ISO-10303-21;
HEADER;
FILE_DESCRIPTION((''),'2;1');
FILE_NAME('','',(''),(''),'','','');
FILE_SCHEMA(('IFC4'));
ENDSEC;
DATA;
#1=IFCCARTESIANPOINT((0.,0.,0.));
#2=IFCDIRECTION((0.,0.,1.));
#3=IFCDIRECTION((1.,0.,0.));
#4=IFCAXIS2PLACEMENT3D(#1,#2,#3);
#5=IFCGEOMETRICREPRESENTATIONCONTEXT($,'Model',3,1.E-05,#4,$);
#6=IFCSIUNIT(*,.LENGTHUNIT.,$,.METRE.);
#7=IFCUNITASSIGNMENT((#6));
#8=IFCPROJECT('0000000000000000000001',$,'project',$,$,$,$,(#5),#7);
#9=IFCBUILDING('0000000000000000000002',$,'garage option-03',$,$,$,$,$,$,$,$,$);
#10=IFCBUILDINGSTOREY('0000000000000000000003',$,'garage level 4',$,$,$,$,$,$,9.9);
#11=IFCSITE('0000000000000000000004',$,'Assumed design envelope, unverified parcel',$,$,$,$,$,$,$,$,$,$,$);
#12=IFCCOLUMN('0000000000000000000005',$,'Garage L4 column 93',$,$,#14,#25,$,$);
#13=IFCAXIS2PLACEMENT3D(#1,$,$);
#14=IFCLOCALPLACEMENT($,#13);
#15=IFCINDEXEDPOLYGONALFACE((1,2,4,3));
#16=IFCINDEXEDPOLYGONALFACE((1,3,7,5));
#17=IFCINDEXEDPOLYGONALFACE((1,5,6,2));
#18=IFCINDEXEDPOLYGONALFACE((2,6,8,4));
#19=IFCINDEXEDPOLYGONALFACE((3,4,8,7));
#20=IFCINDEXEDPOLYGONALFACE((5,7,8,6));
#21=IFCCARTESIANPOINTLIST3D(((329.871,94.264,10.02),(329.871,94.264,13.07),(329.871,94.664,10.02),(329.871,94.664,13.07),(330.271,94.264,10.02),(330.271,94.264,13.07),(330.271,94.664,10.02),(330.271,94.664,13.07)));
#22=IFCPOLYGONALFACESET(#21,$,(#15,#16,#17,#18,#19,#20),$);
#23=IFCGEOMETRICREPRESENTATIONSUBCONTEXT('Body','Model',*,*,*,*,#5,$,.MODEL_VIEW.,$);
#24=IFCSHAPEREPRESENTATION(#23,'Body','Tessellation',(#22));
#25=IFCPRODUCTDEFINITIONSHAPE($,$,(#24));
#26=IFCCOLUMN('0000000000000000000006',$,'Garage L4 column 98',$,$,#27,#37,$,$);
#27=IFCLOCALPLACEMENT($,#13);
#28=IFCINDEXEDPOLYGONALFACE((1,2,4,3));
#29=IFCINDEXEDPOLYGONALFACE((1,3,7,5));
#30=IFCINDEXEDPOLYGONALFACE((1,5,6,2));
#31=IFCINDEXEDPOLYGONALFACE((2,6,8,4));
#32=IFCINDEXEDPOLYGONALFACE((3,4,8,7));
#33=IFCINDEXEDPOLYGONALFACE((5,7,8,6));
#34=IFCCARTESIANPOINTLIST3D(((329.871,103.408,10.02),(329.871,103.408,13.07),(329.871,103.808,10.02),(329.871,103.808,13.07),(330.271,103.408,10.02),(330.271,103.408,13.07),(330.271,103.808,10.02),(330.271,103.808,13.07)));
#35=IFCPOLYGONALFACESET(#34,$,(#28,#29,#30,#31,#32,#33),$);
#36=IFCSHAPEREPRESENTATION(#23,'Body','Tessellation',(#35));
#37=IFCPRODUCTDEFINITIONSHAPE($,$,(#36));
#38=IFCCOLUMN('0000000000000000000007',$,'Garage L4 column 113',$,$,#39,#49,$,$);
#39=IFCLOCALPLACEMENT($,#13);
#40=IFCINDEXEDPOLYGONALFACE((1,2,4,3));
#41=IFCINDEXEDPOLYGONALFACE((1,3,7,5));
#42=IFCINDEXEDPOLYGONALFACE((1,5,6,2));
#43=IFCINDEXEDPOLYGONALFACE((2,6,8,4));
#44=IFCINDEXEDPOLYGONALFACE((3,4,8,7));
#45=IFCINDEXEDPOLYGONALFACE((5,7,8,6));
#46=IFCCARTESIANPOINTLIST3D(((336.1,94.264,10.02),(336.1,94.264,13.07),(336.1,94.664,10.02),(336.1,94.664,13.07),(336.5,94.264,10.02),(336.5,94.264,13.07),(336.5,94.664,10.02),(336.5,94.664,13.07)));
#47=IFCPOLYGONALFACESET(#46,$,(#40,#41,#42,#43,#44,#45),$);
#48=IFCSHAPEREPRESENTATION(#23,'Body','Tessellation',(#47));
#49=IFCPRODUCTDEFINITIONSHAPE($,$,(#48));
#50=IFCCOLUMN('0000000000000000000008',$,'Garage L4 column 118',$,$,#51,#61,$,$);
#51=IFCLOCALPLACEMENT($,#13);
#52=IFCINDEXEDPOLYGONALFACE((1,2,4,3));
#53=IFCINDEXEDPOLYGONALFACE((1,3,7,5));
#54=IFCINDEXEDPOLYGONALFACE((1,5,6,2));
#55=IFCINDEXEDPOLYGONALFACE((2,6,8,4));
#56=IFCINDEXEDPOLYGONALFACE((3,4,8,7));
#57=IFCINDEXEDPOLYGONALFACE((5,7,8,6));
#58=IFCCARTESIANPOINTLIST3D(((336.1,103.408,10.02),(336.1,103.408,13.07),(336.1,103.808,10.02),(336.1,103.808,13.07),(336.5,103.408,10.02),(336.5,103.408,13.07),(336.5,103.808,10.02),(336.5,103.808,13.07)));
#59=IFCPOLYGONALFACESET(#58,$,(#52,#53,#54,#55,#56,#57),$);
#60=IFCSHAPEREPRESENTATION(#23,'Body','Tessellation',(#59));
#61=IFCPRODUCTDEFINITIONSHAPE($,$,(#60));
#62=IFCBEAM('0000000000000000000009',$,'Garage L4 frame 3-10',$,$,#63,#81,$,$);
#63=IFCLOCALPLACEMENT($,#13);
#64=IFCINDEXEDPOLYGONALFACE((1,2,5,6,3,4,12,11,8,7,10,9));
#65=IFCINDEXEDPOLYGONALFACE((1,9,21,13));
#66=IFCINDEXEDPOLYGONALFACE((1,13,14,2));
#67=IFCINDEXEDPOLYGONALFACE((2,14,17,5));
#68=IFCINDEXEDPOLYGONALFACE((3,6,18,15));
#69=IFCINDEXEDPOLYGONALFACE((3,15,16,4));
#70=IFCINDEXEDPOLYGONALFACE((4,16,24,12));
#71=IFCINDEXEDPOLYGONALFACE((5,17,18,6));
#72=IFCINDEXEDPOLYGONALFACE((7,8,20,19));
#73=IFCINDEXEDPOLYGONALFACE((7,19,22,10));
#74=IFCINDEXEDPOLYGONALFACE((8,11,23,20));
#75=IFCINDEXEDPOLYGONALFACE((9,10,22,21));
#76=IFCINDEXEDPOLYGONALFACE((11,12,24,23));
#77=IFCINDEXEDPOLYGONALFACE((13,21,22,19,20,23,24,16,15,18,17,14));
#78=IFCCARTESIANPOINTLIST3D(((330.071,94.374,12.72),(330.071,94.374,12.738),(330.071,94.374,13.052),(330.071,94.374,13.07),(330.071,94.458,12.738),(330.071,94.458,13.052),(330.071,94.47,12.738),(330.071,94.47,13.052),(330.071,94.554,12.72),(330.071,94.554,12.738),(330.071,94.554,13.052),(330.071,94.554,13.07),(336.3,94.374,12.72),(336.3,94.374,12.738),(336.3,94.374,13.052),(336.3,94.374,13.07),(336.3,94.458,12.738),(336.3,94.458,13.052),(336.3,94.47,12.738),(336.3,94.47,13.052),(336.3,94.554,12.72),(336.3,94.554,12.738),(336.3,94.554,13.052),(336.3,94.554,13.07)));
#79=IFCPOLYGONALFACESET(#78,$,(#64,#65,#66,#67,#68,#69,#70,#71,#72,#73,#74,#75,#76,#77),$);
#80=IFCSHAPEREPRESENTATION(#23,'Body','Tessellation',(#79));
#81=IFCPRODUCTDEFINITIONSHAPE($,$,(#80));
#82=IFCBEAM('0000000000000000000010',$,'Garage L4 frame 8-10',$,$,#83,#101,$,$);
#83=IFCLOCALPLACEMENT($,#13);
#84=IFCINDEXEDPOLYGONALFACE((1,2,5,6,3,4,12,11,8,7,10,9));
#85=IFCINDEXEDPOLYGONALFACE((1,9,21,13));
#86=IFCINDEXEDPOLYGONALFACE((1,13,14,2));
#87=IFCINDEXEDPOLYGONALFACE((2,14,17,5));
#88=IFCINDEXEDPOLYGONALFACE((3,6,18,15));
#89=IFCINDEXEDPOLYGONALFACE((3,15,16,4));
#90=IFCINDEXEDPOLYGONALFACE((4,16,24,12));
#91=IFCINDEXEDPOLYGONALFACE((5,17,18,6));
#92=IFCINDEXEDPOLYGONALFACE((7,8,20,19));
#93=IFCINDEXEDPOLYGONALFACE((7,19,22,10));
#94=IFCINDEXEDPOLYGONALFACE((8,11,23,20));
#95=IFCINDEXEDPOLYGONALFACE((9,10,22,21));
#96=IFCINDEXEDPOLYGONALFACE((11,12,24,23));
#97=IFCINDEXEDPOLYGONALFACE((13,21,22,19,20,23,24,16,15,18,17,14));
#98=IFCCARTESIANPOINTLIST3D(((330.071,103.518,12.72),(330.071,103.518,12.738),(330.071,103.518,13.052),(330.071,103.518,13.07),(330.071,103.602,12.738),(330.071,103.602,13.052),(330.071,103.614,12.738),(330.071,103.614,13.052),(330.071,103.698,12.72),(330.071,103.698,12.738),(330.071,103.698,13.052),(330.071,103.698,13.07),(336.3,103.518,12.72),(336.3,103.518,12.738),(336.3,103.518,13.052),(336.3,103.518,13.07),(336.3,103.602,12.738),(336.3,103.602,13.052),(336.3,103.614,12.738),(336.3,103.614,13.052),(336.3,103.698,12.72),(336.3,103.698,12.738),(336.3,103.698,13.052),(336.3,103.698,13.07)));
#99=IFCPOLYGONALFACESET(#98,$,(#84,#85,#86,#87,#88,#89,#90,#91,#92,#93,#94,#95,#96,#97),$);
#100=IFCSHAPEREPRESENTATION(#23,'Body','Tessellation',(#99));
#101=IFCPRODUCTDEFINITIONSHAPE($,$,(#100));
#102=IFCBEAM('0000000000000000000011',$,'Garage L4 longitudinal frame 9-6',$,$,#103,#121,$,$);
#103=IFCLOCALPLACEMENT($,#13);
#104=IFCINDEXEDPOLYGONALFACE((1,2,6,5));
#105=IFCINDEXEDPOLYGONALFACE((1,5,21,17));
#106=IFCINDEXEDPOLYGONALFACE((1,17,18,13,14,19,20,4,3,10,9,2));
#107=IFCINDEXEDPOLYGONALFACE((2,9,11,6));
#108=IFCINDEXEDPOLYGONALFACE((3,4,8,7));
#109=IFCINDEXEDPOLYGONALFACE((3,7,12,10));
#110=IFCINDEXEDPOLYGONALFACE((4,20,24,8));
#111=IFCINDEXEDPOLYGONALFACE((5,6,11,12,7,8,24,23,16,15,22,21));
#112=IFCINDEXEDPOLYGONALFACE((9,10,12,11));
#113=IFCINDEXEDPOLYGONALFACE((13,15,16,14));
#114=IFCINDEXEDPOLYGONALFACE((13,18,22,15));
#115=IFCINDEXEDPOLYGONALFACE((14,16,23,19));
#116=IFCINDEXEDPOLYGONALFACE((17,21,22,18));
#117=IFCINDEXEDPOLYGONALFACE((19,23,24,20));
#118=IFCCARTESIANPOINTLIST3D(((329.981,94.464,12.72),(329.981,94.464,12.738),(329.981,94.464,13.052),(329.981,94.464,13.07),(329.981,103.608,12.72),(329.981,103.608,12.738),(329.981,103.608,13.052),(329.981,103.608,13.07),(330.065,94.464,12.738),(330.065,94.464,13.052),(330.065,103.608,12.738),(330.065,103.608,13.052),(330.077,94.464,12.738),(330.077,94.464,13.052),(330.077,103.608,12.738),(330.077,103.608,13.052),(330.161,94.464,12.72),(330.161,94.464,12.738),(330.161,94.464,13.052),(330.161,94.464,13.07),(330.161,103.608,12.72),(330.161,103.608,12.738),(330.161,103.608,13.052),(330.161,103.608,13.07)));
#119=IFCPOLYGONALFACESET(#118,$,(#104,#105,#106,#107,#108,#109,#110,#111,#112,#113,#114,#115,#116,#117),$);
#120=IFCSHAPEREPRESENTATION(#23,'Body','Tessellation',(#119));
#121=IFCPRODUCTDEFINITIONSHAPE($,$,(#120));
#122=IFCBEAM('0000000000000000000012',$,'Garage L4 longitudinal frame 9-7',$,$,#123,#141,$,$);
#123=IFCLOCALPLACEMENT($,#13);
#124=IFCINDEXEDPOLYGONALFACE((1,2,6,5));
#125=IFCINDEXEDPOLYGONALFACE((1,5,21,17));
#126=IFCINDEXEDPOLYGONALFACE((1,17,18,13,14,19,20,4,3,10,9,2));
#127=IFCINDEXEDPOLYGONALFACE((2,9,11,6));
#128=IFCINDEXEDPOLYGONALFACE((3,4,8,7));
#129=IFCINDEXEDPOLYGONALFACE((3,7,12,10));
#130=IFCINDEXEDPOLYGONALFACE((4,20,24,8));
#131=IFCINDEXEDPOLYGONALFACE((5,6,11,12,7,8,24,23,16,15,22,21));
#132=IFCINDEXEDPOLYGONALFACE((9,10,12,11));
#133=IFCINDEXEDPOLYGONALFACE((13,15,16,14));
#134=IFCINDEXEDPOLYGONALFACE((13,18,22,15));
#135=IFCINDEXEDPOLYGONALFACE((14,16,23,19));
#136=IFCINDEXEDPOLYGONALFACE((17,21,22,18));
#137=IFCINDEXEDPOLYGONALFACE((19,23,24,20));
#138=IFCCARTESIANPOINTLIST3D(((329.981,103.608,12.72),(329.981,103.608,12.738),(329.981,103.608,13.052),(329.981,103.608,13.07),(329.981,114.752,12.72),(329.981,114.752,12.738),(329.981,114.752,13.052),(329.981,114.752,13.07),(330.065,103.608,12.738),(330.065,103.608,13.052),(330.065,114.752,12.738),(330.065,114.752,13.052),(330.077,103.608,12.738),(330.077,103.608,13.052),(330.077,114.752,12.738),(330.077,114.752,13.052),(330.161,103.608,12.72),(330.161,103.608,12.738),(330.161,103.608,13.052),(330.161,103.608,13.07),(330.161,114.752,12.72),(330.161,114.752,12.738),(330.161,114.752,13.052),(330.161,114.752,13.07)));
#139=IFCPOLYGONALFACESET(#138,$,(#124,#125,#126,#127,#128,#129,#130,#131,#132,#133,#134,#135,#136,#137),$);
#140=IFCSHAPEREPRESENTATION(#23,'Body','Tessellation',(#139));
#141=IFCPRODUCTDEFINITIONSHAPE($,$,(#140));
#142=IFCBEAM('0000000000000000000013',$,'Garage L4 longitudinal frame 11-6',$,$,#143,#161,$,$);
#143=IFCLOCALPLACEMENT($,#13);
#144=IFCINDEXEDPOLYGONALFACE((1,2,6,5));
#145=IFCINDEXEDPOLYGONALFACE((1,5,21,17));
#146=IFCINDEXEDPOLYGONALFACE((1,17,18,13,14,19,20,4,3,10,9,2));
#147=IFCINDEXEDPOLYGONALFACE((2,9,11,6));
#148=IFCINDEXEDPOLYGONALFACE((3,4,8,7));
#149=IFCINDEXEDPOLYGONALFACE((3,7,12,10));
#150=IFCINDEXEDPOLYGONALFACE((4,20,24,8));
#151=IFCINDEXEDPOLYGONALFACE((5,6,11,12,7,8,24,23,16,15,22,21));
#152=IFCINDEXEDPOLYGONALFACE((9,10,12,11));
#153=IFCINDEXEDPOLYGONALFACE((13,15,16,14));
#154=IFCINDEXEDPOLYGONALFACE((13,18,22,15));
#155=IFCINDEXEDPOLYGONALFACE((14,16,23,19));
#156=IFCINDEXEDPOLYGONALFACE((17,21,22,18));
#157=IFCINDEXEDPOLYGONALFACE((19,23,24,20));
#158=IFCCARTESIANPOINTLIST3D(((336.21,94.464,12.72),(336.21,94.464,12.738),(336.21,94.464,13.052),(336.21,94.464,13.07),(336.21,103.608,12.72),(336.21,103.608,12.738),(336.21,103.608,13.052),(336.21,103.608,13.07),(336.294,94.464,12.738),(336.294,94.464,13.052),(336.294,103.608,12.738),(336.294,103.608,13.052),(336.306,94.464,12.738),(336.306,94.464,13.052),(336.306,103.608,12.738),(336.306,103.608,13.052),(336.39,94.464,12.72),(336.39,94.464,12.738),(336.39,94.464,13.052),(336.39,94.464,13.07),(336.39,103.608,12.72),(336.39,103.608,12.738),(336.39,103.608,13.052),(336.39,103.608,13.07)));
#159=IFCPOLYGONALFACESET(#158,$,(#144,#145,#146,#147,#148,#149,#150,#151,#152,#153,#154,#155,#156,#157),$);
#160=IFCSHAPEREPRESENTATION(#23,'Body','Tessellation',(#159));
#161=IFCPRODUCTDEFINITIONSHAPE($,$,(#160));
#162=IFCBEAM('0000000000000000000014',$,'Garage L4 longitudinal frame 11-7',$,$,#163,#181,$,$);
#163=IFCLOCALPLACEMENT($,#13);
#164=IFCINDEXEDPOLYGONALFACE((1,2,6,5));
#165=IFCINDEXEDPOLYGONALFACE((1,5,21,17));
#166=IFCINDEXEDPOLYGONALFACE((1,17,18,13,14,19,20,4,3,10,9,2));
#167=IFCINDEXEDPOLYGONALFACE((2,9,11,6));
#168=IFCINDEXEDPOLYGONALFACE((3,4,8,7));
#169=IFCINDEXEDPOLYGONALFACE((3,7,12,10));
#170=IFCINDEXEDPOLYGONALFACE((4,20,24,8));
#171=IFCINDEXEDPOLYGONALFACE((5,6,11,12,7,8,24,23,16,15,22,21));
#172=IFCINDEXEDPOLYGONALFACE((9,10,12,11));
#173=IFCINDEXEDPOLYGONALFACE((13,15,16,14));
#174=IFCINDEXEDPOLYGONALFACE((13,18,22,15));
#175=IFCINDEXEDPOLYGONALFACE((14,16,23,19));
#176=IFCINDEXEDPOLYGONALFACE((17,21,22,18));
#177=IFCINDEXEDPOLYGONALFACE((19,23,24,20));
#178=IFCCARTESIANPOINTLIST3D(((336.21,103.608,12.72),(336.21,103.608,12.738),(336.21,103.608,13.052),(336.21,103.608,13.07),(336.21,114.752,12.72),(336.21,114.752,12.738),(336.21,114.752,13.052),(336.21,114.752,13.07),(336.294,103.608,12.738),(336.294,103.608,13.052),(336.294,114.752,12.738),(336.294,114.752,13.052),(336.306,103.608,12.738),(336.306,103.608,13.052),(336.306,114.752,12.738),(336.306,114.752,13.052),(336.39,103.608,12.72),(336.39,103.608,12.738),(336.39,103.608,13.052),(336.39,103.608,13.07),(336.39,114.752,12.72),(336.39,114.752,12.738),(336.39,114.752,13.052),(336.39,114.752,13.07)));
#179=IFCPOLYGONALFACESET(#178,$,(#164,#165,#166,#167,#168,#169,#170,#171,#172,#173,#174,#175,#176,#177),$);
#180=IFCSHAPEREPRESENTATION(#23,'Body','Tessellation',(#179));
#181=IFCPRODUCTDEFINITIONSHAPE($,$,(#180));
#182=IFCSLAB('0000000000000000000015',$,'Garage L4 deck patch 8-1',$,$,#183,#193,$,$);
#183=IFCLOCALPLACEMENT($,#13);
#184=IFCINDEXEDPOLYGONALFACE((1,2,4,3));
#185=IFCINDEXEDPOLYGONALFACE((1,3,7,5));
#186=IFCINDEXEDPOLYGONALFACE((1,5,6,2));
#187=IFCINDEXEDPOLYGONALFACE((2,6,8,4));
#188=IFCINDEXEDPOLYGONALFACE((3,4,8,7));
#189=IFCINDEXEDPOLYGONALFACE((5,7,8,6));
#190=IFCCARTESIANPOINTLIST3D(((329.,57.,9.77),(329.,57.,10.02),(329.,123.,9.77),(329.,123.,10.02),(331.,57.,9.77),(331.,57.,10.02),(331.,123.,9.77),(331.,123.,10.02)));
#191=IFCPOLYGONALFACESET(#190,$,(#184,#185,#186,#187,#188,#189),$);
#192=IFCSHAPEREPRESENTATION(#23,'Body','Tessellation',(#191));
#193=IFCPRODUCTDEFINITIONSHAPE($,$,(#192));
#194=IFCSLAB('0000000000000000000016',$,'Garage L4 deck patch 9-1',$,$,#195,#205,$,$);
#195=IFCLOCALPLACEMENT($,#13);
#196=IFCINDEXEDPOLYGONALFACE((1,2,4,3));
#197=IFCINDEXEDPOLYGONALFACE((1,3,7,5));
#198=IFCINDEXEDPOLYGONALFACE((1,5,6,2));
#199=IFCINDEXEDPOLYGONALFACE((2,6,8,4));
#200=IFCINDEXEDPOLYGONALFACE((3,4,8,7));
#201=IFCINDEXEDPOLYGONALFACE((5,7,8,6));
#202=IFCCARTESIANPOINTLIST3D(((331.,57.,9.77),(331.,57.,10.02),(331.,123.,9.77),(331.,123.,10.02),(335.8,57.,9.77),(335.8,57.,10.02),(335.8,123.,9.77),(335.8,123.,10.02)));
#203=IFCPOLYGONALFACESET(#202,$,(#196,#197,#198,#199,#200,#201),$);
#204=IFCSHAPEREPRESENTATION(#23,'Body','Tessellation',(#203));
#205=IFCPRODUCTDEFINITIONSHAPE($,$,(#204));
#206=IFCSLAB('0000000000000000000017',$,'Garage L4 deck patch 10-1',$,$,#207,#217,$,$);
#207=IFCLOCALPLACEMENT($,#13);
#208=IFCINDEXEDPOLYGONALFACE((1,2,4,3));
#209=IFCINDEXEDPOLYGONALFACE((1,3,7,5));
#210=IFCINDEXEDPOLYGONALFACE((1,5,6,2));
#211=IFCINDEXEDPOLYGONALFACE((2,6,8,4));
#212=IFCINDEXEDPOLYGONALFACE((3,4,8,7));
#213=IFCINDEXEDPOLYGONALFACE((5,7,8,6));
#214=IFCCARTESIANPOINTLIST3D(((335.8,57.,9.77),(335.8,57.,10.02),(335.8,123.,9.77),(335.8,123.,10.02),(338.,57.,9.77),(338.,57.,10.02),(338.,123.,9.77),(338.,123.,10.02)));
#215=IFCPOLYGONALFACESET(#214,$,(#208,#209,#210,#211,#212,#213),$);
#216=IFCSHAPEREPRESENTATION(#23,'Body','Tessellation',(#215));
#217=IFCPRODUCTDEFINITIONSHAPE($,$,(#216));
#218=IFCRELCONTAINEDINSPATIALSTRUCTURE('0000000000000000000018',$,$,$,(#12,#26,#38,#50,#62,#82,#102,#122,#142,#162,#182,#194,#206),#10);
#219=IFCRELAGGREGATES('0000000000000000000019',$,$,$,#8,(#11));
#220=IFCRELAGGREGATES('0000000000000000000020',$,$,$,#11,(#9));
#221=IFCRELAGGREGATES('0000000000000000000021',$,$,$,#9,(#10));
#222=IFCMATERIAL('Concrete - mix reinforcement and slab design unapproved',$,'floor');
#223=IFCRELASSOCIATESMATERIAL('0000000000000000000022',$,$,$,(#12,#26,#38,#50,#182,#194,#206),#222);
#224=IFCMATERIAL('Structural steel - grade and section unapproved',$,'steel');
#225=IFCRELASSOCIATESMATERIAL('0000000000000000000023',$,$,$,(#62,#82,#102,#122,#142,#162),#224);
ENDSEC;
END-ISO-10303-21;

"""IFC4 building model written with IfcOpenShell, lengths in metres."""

from ifc_helpers import new_model, si_unit, frame, origin_with_axes, place, context, subcontext, project, spatial, rectangle, i_section, extrude, material, element, save


model = new_model("IFC4")

# Units and contexts
model_context = context("Model", 3, precision=1e-05, world=origin_with_axes())
body_context = subcontext(model_context, "Body", "Model", "MODEL_VIEW")
ifc_project = project(units=[si_unit("LENGTHUNIT", "METRE")], contexts=[model_context])

# Site, building, storey
site = spatial("IfcSite", under=ifc_project, Name="Assumed design envelope, unverified parcel")
building = spatial("IfcBuilding", under=site, Name="garage option-03")
storey = spatial("IfcBuildingStorey", under=building, Name="garage level 4", Elevation=9.9)

# Columns
ifc_material_1 = material(Name="Concrete - mix reinforcement and slab design unapproved", Category="floor")
for number, where, z_axis, x_axis, name in (
    (1, (330.071, 94.464, 10.02), (0.0, 0.0, 1.0), (1.0, 0.0, 0.0), "Garage L4 column 93"),
    (2, (330.071, 103.608, 10.02), (0.0, 0.0, 1.0), (1.0, 0.0, 0.0), "Garage L4 column 98"),
    (3, (336.3, 94.464, 10.02), (0.0, 0.0, 1.0), (1.0, 0.0, 0.0), "Garage L4 column 113"),
    (4, (336.3, 103.608, 10.02), (0.0, 0.0, 1.0), (1.0, 0.0, 0.0), "Garage L4 column 118"),
):
    element("IfcColumn", number, at=place(None, frame(where, z_axis=z_axis, x_axis=x_axis)), inside=storey, material=ifc_material_1, Name=name, context=body_context, shape_type="SweptSolid", body=[
        extrude(rectangle(XDim=0.4, YDim=0.4), origin_with_axes(), (0.0, 0.0, 1.0), 3.05),
    ])

# Beams
ifc_material_2 = material(Name="Structural steel - grade and section unapproved", Category="steel")
for number, where, z_axis, x_axis, name in (
    (5, (330.071, 94.464, 12.895), (1.0, 0.0, 0.0), (0.0, 1.0, 0.0), "Garage L4 frame 3-10"),
    (6, (330.071, 103.608, 12.895), (1.0, 0.0, 0.0), (0.0, 1.0, 0.0), "Garage L4 frame 8-10"),
):
    element("IfcBeam", number, at=place(None, frame(where, z_axis=z_axis, x_axis=x_axis)), inside=storey, material=ifc_material_2, Name=name, context=body_context, shape_type="SweptSolid", body=[
        extrude(i_section(OverallWidth=0.18, OverallDepth=0.35, WebThickness=0.012, FlangeThickness=0.018, FilletRadius=0.0), origin_with_axes(), (0.0, 0.0, 1.0), 6.229),
    ])
beam_1_placement = place(None, frame((330.071, 94.464, 12.895), z_axis=(0.0, 1.0, 0.0), x_axis=(-1.0, 0.0, 0.0)))
element("IfcBeam", 7, at=beam_1_placement, inside=storey, material=ifc_material_2, Name="Garage L4 longitudinal frame 9-6", context=body_context, shape_type="SweptSolid", body=[
    extrude(i_section(OverallWidth=0.18, OverallDepth=0.35, WebThickness=0.012, FlangeThickness=0.018, FilletRadius=0.0), origin_with_axes(), (0.0, 0.0, 1.0), 9.144),
])
beam_2_placement = place(None, frame((330.071, 103.608, 12.895), z_axis=(0.0, 1.0, 0.0), x_axis=(-1.0, 0.0, 0.0)))
element("IfcBeam", 8, at=beam_2_placement, inside=storey, material=ifc_material_2, Name="Garage L4 longitudinal frame 9-7", context=body_context, shape_type="SweptSolid", body=[
    extrude(i_section(OverallWidth=0.18, OverallDepth=0.35, WebThickness=0.012, FlangeThickness=0.018, FilletRadius=0.0), origin_with_axes(), (0.0, 0.0, 1.0), 11.144),
])
beam_3_placement = place(None, frame((336.3, 94.464, 12.895), z_axis=(0.0, 1.0, 0.0), x_axis=(-1.0, 0.0, 0.0)))
element("IfcBeam", 9, at=beam_3_placement, inside=storey, material=ifc_material_2, Name="Garage L4 longitudinal frame 11-6", context=body_context, shape_type="SweptSolid", body=[
    extrude(i_section(OverallWidth=0.18, OverallDepth=0.35, WebThickness=0.012, FlangeThickness=0.018, FilletRadius=0.0), origin_with_axes(), (0.0, 0.0, 1.0), 9.144),
])
beam_4_placement = place(None, frame((336.3, 103.608, 12.895), z_axis=(0.0, 1.0, 0.0), x_axis=(-1.0, 0.0, 0.0)))
element("IfcBeam", 10, at=beam_4_placement, inside=storey, material=ifc_material_2, Name="Garage L4 longitudinal frame 11-7", context=body_context, shape_type="SweptSolid", body=[
    extrude(i_section(OverallWidth=0.18, OverallDepth=0.35, WebThickness=0.012, FlangeThickness=0.018, FilletRadius=0.0), origin_with_axes(), (0.0, 0.0, 1.0), 11.144),
])

# Slabs
slab_1_placement = place(None, frame((330.0, 90.0, 9.77), z_axis=(0.0, 0.0, 1.0), x_axis=(1.0, 0.0, 0.0)))
element("IfcSlab", 11, at=slab_1_placement, inside=storey, material=ifc_material_1, Name="Garage L4 deck patch 8-1", context=body_context, shape_type="SweptSolid", body=[
    extrude(rectangle(XDim=2.0, YDim=66.0), origin_with_axes(), (0.0, 0.0, 1.0), 0.25),
])
slab_2_placement = place(None, frame((333.4, 90.0, 9.77), z_axis=(0.0, 0.0, 1.0), x_axis=(1.0, 0.0, 0.0)))
element("IfcSlab", 12, at=slab_2_placement, inside=storey, material=ifc_material_1, Name="Garage L4 deck patch 9-1", context=body_context, shape_type="SweptSolid", body=[
    extrude(rectangle(XDim=4.8, YDim=66.0), origin_with_axes(), (0.0, 0.0, 1.0), 0.25),
])
slab_3_placement = place(None, frame((336.9, 90.0, 9.77), z_axis=(0.0, 0.0, 1.0), x_axis=(1.0, 0.0, 0.0)))
element("IfcSlab", 13, at=slab_3_placement, inside=storey, material=ifc_material_1, Name="Garage L4 deck patch 10-1", context=body_context, shape_type="SweptSolid", body=[
    extrude(rectangle(XDim=2.2, YDim=66.0), origin_with_axes(), (0.0, 0.0, 1.0), 0.25),
])

save(model, "model.ifc")
